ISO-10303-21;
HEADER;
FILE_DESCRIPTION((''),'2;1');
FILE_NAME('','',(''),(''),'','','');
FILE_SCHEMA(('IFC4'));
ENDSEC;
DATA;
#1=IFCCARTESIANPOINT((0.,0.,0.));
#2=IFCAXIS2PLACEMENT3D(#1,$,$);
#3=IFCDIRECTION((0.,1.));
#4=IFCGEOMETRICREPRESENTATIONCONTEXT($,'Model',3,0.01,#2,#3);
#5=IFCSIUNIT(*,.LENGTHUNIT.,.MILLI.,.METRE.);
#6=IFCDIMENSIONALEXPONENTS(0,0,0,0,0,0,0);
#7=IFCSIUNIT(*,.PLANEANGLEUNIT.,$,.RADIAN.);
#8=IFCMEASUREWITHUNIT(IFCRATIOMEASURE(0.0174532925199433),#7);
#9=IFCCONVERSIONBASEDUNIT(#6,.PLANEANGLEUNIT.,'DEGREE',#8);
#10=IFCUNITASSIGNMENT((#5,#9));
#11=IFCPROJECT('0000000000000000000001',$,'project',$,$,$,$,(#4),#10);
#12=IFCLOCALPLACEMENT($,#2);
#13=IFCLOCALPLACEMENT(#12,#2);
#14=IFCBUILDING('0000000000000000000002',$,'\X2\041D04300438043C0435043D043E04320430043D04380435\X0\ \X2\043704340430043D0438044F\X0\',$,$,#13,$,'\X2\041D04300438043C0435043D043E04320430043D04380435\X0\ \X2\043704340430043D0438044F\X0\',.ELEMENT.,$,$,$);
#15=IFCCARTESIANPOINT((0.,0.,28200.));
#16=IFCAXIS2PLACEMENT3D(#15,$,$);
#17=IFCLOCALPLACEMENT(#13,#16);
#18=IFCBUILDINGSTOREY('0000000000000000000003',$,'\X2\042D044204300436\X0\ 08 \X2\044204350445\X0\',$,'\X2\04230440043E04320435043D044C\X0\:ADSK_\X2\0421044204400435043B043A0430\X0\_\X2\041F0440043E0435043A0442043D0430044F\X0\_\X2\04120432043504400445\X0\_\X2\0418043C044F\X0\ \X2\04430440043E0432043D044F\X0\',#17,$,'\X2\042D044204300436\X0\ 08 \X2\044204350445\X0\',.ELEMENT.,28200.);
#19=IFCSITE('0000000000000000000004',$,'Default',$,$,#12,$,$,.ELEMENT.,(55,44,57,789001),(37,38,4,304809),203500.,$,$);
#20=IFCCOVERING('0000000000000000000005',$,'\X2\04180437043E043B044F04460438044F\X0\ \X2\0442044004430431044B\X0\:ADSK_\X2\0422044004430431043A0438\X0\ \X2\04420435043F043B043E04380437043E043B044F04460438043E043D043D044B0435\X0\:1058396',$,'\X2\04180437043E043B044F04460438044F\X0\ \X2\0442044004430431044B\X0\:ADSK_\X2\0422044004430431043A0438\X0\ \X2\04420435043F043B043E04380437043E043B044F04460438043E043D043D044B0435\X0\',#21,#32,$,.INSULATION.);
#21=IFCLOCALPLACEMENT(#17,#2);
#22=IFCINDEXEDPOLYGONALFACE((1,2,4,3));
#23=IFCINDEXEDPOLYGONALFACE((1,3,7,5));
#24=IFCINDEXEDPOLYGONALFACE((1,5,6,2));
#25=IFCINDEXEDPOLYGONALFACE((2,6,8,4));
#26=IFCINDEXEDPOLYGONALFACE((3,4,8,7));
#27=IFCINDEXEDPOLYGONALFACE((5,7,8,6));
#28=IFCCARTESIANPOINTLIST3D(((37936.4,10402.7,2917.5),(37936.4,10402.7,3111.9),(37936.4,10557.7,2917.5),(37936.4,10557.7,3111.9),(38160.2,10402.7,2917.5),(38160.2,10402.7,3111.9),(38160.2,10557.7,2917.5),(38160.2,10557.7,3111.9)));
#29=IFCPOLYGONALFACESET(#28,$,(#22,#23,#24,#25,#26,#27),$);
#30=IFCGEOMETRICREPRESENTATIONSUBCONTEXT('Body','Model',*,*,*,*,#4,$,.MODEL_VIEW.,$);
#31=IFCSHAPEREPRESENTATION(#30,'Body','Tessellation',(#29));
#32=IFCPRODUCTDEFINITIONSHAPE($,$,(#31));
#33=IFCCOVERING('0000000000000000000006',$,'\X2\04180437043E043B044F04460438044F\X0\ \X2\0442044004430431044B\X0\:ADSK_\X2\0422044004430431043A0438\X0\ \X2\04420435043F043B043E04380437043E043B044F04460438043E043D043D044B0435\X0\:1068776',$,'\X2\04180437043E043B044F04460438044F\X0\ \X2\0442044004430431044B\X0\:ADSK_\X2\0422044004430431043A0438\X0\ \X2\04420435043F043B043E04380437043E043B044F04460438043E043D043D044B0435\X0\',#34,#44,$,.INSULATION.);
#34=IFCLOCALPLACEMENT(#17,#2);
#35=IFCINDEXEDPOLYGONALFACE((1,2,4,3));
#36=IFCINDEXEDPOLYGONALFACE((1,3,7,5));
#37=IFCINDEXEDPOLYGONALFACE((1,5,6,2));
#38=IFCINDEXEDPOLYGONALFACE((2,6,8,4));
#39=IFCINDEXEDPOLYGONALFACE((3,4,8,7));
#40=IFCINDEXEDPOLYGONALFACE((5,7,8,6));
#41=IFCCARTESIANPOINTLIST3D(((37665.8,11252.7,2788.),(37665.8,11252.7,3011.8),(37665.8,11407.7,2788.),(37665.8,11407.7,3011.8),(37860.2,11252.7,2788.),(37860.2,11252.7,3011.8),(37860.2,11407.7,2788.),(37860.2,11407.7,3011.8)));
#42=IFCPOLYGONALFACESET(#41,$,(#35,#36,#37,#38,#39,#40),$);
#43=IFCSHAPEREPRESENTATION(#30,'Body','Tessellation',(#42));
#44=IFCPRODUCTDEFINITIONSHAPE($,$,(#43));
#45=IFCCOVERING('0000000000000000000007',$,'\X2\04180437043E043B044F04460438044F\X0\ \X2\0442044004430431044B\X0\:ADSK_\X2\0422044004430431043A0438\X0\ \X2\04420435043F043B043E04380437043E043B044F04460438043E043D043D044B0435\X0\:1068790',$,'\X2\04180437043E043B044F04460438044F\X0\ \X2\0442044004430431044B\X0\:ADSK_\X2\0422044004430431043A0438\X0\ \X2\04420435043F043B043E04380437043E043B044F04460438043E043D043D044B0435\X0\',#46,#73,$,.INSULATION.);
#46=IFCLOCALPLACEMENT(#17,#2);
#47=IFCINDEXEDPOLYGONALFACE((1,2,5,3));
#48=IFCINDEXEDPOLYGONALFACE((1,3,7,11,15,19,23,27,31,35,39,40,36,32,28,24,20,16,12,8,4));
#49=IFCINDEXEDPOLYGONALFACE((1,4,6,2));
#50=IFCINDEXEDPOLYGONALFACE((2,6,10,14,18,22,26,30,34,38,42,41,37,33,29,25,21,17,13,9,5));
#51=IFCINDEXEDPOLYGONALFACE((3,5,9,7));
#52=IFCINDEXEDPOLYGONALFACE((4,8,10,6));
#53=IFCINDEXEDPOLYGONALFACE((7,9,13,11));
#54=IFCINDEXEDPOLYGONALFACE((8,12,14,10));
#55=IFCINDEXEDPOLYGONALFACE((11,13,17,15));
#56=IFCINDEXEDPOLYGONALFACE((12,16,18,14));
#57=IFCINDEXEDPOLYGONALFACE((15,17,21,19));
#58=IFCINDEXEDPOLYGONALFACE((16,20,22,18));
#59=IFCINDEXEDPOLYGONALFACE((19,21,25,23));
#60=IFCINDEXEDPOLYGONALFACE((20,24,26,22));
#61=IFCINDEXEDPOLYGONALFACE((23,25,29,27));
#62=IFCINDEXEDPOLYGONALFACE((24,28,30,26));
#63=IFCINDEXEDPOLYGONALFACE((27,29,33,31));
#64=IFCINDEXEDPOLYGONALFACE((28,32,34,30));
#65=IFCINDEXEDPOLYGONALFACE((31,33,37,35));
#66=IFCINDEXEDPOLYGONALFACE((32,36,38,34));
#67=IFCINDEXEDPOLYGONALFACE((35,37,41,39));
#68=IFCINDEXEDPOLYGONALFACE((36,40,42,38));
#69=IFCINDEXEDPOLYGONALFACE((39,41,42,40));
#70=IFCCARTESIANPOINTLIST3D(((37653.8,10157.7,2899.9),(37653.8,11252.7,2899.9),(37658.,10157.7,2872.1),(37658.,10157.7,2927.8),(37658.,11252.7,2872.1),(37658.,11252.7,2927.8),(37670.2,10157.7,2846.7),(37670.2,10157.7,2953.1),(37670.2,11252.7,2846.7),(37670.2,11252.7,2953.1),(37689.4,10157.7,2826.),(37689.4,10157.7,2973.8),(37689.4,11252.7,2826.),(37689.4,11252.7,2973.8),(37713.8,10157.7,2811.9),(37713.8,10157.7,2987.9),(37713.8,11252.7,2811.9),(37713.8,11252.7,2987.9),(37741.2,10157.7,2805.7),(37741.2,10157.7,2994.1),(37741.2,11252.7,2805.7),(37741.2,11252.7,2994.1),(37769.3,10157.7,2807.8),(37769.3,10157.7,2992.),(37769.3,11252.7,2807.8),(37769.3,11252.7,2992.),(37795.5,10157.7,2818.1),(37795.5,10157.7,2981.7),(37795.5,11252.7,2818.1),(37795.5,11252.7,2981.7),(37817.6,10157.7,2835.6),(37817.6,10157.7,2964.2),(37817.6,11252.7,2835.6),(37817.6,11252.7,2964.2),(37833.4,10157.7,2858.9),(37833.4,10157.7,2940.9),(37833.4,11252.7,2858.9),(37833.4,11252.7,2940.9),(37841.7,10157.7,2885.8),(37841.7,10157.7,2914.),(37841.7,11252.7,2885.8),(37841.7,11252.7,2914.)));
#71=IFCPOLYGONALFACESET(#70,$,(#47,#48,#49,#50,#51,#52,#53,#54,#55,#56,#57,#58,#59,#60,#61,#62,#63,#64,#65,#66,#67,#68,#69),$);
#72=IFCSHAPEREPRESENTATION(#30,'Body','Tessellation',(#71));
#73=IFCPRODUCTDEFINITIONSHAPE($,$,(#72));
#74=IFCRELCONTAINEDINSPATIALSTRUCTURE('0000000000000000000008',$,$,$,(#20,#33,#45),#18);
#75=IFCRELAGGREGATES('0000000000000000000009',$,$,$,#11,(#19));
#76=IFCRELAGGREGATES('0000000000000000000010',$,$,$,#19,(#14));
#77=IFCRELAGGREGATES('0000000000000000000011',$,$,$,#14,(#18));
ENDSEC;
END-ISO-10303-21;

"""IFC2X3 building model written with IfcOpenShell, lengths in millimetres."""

from ifc_helpers import new_model, entity, si_unit, converted_unit, direction, frame, origin, origin_2d_with_axis, place, context, subcontext, project, spatial, rectangle, circle, extrude, element, save


model = new_model("IFC2X3")

# Units and contexts
model_context = context("Model", 3, precision=0.01, world=origin(), true_north=direction((0.0, 1.0)))
body_context = subcontext(model_context, "Body", "Model", "MODEL_VIEW")
ifc_project = project(units=[si_unit("LENGTHUNIT", "METRE", prefix="MILLI"), converted_unit("PLANEANGLEUNIT", "DEGREE", entity("IfcRatioMeasure", 0.0174532925199433), si_unit("PLANEANGLEUNIT", "RADIAN"), dimensions=[0, 0, 0, 0, 0, 0, 0])], contexts=[model_context])

# Site, building, storey
site_placement = place(None, origin())
site = spatial("IfcSite", under=ifc_project, at=site_placement, Name="Default", CompositionType="ELEMENT", RefLatitude=(55, 44, 57, 789001), RefLongitude=(37, 38, 4, 304809), RefElevation=203500.0)
building_placement = place(site_placement, origin())
building = spatial("IfcBuilding", under=site, at=building_placement, Name="Наименование здания", LongName="Наименование здания", CompositionType="ELEMENT")
storey_placement = place(building_placement, frame((0.0, 0.0, 28200.0)))
storey = spatial("IfcBuildingStorey", under=building, at=storey_placement, Name="Этаж 08 тех", ObjectType="Уровень:ADSK_Стрелка_Проектная_Вверх_Имя уровня", LongName="Этаж 08 тех", CompositionType="ELEMENT", Elevation=28200.0)

# Coverings
covering_1_placement = place(storey_placement, frame((37936.4, 10402.7, 2917.5)))
element("IfcCovering", 1, at=covering_1_placement, inside=storey, Name="Изоляция трубы:ADSK_Трубки теплоизоляционные:1058396", ObjectType="Изоляция трубы:ADSK_Трубки теплоизоляционные", PredefinedType="INSULATION", context=body_context, shape_type="SweptSolid", body=[
    extrude(rectangle(XDim=155.0, YDim=223.8, at=origin_2d_with_axis()), frame((111.9, 77.5, 0.0), z_axis=(0.0, 0.0, 1.0), x_axis=(0.0, 1.0, 0.0)), (0.0, 0.0, 1.0), 194.4),
])
covering_2_placement = place(storey_placement, frame((37665.8, 11252.7, 2788.0)))
element("IfcCovering", 2, at=covering_2_placement, inside=storey, Name="Изоляция трубы:ADSK_Трубки теплоизоляционные:1068776", ObjectType="Изоляция трубы:ADSK_Трубки теплоизоляционные", PredefinedType="INSULATION", context=body_context, shape_type="SweptSolid", body=[
    extrude(rectangle(XDim=155.0, YDim=194.4, at=origin_2d_with_axis()), frame((97.2, 77.5, 0.0), z_axis=(0.0, 0.0, 1.0), x_axis=(0.0, -1.0, 0.0)), (0.0, 0.0, 1.0), 223.8),
])
covering_3_placement = place(storey_placement, frame((37652.2, 10157.7, 2803.8)))
element("IfcCovering", 3, at=covering_3_placement, inside=storey, Name="Изоляция трубы:ADSK_Трубки теплоизоляционные:1068790", ObjectType="Изоляция трубы:ADSK_Трубки теплоизоляционные", PredefinedType="INSULATION", context=body_context, shape_type="SweptSolid", body=[
    extrude(circle(Radius=94.5, at=origin_2d_with_axis()), frame((96.1, 0.0, 96.1), z_axis=(0.0, 1.0, -0.000001), x_axis=(-1.0, 0.0, 0.0)), (0.0, 0.0, 1.0), 1095.0),
])

save(model, "model.ifc")
